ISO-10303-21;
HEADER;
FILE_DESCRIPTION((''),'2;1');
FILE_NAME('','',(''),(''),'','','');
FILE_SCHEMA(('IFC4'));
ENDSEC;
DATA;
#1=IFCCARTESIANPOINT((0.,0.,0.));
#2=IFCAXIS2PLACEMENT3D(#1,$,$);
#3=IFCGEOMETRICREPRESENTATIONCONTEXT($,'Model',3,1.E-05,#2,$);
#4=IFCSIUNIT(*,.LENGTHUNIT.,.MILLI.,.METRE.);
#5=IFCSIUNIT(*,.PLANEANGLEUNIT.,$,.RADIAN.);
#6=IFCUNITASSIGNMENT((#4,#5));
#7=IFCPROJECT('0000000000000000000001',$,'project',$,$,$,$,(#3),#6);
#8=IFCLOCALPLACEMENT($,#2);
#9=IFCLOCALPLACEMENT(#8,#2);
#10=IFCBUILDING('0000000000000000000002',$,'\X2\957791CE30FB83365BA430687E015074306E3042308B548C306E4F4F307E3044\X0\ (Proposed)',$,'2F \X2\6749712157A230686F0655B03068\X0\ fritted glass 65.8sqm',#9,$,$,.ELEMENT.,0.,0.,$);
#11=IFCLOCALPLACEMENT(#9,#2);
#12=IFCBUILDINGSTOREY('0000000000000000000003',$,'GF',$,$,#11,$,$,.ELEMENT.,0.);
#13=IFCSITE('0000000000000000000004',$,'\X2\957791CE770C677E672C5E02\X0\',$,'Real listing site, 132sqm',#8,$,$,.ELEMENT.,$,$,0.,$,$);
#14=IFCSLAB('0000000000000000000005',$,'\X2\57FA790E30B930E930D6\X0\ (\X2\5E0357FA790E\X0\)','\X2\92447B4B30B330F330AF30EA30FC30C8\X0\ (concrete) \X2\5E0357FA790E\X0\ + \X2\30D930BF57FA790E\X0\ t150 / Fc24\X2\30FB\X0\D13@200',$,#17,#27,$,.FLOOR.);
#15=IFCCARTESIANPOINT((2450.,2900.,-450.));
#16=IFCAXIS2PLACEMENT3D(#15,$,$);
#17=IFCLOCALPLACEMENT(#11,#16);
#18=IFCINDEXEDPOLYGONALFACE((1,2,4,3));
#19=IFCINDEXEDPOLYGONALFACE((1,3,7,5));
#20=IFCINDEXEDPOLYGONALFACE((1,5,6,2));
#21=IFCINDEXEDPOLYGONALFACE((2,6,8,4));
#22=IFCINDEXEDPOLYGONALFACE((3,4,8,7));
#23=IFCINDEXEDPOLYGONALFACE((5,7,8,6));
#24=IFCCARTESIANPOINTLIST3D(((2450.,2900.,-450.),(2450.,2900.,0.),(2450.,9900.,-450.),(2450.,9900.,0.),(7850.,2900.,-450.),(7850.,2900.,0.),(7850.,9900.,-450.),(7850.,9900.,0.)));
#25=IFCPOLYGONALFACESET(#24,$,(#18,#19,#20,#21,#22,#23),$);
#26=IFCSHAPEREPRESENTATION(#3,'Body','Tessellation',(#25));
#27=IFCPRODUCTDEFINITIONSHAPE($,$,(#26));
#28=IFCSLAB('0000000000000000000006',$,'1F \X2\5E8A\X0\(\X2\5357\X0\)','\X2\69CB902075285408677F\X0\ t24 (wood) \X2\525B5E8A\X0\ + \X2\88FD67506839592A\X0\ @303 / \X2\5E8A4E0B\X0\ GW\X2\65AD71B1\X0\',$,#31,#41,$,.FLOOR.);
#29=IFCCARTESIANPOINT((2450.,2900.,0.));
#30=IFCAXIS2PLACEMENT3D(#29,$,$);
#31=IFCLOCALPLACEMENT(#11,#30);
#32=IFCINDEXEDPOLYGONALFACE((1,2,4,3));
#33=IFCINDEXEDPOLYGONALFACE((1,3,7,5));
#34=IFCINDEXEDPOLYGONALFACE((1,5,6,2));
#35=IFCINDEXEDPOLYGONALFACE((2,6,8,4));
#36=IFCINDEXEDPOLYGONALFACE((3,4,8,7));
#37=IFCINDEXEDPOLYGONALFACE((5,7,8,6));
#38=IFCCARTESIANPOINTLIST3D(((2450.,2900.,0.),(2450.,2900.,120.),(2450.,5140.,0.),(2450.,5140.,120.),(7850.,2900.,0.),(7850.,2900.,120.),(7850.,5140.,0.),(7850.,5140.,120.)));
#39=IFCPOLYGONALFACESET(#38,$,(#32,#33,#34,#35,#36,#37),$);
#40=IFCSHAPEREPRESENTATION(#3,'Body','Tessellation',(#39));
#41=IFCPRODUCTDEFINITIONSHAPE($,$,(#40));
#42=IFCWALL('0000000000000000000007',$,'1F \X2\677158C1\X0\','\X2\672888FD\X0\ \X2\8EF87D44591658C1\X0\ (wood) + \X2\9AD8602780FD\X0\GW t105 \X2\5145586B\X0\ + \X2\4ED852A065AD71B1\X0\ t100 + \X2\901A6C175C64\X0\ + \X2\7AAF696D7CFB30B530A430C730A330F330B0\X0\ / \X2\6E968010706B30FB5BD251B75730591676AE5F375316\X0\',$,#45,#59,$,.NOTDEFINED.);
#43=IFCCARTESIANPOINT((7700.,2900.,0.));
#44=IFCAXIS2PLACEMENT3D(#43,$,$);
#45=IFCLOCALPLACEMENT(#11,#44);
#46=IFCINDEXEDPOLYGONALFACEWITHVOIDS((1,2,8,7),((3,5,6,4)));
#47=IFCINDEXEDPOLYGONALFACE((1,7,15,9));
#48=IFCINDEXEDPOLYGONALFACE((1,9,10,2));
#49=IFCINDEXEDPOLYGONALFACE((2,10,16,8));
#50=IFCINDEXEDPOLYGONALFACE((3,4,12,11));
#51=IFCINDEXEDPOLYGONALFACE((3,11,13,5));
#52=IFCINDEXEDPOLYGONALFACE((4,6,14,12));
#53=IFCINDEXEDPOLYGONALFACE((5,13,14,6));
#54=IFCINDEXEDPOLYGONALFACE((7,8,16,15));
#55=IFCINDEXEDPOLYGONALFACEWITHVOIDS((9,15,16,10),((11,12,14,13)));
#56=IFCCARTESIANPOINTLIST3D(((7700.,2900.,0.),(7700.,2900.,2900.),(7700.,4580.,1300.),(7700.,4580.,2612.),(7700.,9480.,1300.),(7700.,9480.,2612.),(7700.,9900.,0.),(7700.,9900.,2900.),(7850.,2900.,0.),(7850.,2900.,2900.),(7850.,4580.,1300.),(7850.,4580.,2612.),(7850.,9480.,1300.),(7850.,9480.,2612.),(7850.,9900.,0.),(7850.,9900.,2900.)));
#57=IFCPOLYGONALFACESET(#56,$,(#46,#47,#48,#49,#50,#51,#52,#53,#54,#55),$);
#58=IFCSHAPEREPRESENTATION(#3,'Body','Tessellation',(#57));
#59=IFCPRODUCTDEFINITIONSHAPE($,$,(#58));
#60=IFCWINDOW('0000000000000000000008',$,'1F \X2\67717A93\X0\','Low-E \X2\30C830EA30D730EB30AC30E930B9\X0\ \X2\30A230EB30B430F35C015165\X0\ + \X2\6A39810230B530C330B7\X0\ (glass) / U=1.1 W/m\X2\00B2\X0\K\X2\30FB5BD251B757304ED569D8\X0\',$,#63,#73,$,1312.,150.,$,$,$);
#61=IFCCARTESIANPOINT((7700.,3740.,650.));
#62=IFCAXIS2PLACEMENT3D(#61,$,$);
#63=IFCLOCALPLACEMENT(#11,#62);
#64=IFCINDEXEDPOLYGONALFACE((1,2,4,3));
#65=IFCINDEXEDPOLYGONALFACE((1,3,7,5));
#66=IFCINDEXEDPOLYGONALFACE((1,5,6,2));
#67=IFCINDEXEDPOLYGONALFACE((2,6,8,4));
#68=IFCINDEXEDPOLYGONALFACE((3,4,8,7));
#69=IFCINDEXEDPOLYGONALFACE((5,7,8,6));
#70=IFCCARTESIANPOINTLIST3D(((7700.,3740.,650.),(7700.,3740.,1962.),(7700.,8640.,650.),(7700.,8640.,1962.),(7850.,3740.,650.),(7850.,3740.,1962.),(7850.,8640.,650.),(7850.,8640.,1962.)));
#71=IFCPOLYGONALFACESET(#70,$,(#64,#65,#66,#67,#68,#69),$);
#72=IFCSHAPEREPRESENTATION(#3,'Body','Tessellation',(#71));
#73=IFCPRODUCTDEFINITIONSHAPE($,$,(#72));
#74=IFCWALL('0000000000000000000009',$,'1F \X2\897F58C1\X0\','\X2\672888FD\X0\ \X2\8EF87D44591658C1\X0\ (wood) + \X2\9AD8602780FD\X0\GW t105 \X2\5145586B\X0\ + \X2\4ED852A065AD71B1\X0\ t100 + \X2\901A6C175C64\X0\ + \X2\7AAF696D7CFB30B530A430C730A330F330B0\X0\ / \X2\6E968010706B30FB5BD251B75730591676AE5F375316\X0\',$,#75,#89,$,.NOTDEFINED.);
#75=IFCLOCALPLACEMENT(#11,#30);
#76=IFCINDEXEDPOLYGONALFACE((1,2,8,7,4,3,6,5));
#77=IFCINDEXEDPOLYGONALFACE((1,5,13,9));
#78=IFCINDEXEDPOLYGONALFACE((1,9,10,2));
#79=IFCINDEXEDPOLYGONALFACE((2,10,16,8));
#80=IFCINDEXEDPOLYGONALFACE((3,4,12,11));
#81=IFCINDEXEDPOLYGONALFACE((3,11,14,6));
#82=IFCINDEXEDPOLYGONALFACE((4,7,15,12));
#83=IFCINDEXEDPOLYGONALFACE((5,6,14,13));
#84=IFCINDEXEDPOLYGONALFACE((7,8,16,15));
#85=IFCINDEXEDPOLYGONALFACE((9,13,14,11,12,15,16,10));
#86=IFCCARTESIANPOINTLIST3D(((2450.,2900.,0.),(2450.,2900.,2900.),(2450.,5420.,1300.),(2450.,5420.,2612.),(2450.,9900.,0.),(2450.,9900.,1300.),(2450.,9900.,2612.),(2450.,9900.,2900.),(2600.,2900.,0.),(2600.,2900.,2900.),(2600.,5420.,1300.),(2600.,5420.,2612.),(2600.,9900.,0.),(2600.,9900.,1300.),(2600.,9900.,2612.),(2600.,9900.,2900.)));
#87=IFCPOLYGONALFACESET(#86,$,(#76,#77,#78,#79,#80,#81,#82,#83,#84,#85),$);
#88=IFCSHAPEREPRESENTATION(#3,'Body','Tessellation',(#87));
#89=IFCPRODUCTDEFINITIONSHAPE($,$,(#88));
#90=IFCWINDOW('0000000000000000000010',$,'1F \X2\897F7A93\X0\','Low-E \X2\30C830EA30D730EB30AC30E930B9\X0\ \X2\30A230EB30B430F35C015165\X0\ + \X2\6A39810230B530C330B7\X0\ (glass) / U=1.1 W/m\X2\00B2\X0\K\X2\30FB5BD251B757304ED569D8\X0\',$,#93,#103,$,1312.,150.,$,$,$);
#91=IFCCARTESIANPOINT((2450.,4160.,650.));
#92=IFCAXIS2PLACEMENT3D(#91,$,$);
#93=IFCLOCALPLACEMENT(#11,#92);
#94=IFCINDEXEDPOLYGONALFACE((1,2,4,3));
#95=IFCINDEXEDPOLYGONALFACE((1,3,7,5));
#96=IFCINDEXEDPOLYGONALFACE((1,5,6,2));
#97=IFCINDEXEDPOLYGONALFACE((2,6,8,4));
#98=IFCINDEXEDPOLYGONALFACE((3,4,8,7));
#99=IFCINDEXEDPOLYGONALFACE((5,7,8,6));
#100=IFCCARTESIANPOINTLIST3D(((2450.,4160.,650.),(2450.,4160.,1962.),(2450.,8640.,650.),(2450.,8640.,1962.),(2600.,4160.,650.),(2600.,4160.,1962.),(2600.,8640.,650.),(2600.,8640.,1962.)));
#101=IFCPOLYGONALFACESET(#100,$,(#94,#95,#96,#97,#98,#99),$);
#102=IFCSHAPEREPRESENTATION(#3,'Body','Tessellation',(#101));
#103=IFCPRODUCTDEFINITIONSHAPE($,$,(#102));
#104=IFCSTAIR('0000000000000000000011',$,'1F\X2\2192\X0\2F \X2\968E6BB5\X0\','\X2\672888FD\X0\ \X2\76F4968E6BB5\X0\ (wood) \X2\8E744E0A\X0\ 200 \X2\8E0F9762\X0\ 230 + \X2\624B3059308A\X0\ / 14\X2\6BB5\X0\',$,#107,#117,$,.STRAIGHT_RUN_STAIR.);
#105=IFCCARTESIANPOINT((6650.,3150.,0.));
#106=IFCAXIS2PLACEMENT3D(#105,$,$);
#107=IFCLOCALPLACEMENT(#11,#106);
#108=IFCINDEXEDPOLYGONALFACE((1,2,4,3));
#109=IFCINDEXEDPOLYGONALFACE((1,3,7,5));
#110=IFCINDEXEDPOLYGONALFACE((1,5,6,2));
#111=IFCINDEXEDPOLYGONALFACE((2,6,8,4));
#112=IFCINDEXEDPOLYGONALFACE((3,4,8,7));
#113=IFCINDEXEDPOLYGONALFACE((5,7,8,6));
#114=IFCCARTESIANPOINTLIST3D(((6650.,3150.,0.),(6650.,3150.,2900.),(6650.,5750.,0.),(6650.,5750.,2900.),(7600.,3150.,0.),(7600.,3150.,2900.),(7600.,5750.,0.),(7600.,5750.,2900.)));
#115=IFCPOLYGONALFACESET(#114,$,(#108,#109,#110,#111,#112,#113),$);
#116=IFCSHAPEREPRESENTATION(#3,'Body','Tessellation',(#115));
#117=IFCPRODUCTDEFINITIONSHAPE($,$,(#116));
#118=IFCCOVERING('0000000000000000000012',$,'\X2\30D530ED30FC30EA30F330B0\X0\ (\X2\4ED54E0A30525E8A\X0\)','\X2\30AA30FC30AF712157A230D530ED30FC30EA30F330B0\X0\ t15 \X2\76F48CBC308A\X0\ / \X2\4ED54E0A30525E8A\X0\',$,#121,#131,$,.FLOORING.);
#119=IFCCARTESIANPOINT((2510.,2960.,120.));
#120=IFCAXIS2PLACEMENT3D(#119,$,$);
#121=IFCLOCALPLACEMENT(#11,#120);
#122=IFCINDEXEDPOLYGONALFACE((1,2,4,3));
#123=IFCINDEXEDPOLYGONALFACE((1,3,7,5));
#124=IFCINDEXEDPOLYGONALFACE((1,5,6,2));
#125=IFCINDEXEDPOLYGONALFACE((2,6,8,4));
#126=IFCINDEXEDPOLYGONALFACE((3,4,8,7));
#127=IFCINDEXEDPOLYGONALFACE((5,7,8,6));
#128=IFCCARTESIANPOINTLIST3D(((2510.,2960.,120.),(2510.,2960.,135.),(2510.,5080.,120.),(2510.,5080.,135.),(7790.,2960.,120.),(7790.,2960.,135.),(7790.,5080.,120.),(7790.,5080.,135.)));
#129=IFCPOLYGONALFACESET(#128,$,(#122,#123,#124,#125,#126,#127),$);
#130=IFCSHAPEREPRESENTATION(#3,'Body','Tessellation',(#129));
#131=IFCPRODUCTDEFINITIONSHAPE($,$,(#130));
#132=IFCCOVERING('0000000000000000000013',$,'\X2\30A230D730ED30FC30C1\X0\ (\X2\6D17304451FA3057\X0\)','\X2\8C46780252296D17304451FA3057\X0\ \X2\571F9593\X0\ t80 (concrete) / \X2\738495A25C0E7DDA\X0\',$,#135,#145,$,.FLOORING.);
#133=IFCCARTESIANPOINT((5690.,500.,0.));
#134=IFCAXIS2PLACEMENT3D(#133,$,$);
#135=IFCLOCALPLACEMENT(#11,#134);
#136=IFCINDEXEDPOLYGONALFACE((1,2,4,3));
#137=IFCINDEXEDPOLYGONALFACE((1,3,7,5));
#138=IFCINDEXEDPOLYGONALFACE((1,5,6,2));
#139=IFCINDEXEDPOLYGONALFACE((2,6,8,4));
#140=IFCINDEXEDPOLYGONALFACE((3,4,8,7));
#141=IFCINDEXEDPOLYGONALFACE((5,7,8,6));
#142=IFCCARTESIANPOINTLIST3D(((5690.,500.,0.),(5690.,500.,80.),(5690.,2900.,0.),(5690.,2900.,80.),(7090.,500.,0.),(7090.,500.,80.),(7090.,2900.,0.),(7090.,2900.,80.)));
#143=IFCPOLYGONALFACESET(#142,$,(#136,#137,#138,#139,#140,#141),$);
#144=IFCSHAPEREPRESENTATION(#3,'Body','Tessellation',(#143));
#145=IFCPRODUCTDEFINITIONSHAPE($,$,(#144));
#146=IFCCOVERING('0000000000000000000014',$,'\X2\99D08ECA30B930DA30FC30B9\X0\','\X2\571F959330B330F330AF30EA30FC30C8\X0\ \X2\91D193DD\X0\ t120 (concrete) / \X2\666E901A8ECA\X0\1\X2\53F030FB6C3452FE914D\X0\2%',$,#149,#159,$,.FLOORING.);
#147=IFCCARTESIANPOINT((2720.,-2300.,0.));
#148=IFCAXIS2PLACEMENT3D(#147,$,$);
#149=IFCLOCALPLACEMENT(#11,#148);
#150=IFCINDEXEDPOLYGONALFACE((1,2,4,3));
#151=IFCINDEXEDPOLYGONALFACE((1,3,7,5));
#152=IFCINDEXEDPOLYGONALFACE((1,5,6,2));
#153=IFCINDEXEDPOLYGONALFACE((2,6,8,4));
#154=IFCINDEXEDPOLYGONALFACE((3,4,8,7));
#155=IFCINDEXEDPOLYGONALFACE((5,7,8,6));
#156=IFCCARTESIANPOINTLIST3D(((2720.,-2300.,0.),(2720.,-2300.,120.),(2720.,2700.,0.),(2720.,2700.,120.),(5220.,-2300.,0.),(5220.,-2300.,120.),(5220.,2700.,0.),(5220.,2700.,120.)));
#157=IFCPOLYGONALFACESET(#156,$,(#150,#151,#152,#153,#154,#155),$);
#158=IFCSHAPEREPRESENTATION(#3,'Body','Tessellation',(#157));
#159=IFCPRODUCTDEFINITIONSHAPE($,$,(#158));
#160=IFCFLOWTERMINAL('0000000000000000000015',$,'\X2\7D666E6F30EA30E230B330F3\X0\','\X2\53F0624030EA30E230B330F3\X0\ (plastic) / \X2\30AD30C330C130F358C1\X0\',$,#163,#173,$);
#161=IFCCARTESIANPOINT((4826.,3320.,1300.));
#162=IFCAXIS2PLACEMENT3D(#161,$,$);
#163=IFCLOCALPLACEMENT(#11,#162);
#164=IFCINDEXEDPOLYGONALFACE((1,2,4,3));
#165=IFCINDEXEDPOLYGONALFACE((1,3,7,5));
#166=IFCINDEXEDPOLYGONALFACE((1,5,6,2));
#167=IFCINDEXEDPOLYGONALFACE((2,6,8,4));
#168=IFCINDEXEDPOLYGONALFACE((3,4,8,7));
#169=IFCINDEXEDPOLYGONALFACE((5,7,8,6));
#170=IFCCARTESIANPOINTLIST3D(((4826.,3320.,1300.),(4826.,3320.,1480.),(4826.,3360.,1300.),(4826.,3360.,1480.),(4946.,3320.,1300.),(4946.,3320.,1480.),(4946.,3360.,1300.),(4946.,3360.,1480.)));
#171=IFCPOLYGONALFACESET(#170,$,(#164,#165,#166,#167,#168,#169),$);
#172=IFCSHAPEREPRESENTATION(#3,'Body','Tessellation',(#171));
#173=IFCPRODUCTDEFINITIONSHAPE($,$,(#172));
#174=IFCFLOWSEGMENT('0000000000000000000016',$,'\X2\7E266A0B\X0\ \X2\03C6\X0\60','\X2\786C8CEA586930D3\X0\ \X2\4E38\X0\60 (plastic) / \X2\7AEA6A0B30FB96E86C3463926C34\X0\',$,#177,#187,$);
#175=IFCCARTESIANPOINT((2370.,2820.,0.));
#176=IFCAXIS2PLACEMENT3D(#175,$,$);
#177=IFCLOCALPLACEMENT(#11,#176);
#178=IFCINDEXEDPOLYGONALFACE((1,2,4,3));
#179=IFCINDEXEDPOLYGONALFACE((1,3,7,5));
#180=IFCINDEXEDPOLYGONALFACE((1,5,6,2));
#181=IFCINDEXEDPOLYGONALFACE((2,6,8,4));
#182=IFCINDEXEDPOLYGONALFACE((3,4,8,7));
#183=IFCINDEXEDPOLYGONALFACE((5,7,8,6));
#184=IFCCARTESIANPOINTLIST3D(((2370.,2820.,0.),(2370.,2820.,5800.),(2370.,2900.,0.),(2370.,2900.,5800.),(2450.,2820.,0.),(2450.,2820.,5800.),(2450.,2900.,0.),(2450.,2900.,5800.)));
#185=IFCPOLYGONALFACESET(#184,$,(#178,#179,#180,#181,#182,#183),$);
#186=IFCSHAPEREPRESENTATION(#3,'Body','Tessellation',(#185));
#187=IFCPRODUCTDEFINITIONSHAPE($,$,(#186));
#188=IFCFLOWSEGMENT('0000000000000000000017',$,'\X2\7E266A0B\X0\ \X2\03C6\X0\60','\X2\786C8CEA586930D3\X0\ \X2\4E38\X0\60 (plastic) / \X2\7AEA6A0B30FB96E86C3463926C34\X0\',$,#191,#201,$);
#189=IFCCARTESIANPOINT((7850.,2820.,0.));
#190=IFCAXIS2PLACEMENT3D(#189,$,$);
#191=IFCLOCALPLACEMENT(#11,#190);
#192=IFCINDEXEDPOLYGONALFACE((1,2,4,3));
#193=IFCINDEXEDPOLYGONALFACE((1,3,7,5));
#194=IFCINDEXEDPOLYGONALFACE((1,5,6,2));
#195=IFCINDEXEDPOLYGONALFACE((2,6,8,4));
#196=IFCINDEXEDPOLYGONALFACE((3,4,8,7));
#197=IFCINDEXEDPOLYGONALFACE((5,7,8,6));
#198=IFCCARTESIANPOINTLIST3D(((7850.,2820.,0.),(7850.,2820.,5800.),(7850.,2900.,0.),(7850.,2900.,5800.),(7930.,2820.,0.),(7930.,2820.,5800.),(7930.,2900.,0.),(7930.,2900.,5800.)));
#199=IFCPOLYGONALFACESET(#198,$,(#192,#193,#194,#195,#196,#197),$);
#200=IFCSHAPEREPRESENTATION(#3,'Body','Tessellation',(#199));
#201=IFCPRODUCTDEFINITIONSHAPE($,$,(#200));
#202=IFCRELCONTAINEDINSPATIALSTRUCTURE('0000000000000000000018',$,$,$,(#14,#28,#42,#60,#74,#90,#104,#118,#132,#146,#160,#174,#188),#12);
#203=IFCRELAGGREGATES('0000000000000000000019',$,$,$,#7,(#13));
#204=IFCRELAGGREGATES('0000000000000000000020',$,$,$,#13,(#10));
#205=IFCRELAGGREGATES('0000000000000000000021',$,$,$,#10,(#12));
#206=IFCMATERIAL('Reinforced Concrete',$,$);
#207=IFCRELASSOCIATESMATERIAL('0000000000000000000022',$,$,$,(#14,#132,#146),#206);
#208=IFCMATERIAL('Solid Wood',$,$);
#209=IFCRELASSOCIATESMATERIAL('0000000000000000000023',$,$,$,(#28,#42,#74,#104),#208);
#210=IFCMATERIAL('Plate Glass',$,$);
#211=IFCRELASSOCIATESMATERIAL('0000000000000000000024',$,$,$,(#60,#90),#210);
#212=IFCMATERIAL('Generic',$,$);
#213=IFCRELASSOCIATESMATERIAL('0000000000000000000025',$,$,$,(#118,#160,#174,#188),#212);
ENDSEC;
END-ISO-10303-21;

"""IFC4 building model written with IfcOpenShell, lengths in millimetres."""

from ifc_helpers import new_model, si_unit, frame, frame_2d, origin, place, context, project, spatial, rectangle, extrude, material, element, fill, save


model = new_model("IFC4")

# Units and contexts
model_context = context("Model", 3, precision=1e-05, world=origin())
ifc_project = project(units=[si_unit("LENGTHUNIT", "METRE", prefix="MILLI"), si_unit("PLANEANGLEUNIT", "RADIAN")], contexts=[model_context])

# Site, building, storey
site_placement = place(None, origin())
site = spatial("IfcSite", under=ifc_project, at=site_placement, Name="長野県松本市", ObjectType="Real listing site, 132sqm", CompositionType="ELEMENT", RefElevation=0.0)
building_placement = place(site_placement, origin())
building = spatial("IfcBuilding", under=site, at=building_placement, Name="長野・茶室と縁側のある和の住まい (Proposed)", ObjectType="2F 杉無垢と漆喰と fritted glass 65.8sqm", CompositionType="ELEMENT", ElevationOfRefHeight=0.0, ElevationOfTerrain=0.0)
storey_placement = place(building_placement, origin())
storey = spatial("IfcBuildingStorey", under=building, at=storey_placement, Name="GF", CompositionType="ELEMENT", Elevation=0.0)

# Shared definitions
ifc_material_1 = material(Name="Solid Wood")

# Slabs
ifc_material_2 = material(Name="Reinforced Concrete")
slab_1_placement = place(storey_placement, frame((2450.0, 2900.0, -450.0)))
element("IfcSlab", 1, at=slab_1_placement, inside=storey, material=ifc_material_2, Name="基礎スラブ (布基礎)", Description="鉄筋コンクリート (concrete) 布基礎 + ベタ基礎 t150 / Fc24・D13@200", PredefinedType="FLOOR", context=model_context, shape_type="SweptSolid", body=[
    extrude(rectangle(XDim=5400.0, YDim=7000.0, at=frame_2d((2700.0, 3500.0))), frame((2450.0, 2900.0, -450.0)), (0.0, 0.0, 1.0), 450.0),
])
slab_2_placement = place(storey_placement, frame((2450.0, 2900.0, 0.0)))
element("IfcSlab", 2, at=slab_2_placement, inside=storey, material=ifc_material_1, Name="1F 床(南)", Description="構造用合板 t24 (wood) 剛床 + 製材根太 @303 / 床下 GW断熱", PredefinedType="FLOOR", context=model_context, shape_type="SweptSolid", body=[
    extrude(rectangle(XDim=5400.0, YDim=2240.0, at=frame_2d((2700.0, 1120.0))), frame((2450.0, 2900.0, 0.0)), (0.0, 0.0, 1.0), 120.0),
])

# Shared definitions
ifc_material_3 = material(Name="Plate Glass")

# Walls, openings, windows
wall_1_placement = place(storey_placement, frame((7700.0, 2900.0, 0.0)))
wall_1 = element("IfcWall", 3, at=wall_1_placement, inside=storey, material=ifc_material_1, Name="1F 東壁", Description="木製 軸組外壁 (wood) + 高性能GW t105 充填 + 付加断熱 t100 + 通気層 + 窯業系サイディング / 準耐火・寒冷地外皮強化", PredefinedType="NOTDEFINED", context=model_context, shape_type="SweptSolid", body=[
    extrude(rectangle(XDim=150.0, YDim=7000.0, at=frame_2d((75.0, 3500.0))), frame((7700.0, 2900.0, 0.0)), (0.0, 0.0, 1.0), 2900.0),
])
opening_1_placement = place(storey_placement, frame((7700.0, 3740.0, 650.0)))
opening_1 = element("IfcOpeningElement", 4, at=opening_1_placement, cuts=wall_1, PredefinedType="NOTDEFINED", context=model_context, shape_type="SweptSolid", body=[
    extrude(rectangle(XDim=150.0, YDim=4900.0, at=frame_2d((75.0, 2450.0))), frame((7700.0, 3740.0, 650.0)), (0.0, 0.0, 1.0), 1312.0),
])
window_1_placement = place(storey_placement, frame((7700.0, 3740.0, 650.0)))
window_1 = element("IfcWindow", 5, at=window_1_placement, inside=storey, material=ifc_material_3, Name="1F 東窓", Description="Low-E トリプルガラス アルゴン封入 + 樹脂サッシ (glass) / U=1.1 W/m²K・寒冷地仕様", OverallHeight=1312.0, OverallWidth=150.0, context=model_context, shape_type="SweptSolid", body=[
    extrude(rectangle(XDim=150.0, YDim=4900.0, at=frame_2d((75.0, 2450.0))), frame((7700.0, 3740.0, 650.0)), (0.0, 0.0, 1.0), 1312.0),
])
fill(opening_1, window_1)
wall_2_placement = place(storey_placement, frame((2450.0, 2900.0, 0.0)))
wall_2 = element("IfcWall", 6, at=wall_2_placement, inside=storey, material=ifc_material_1, Name="1F 西壁", Description="木製 軸組外壁 (wood) + 高性能GW t105 充填 + 付加断熱 t100 + 通気層 + 窯業系サイディング / 準耐火・寒冷地外皮強化", PredefinedType="NOTDEFINED", context=model_context, shape_type="SweptSolid", body=[
    extrude(rectangle(XDim=150.0, YDim=7000.0, at=frame_2d((75.0, 3500.0))), frame((2450.0, 2900.0, 0.0)), (0.0, 0.0, 1.0), 2900.0),
])
opening_2_placement = place(storey_placement, frame((2450.0, 4160.0, 650.0)))
opening_2 = element("IfcOpeningElement", 7, at=opening_2_placement, cuts=wall_2, PredefinedType="NOTDEFINED", context=model_context, shape_type="SweptSolid", body=[
    extrude(rectangle(XDim=150.0, YDim=4480.0, at=frame_2d((75.0, 2240.0))), frame((2450.0, 4160.0, 650.0)), (0.0, 0.0, 1.0), 1312.0),
])
window_2_placement = place(storey_placement, frame((2450.0, 4160.0, 650.0)))
window_2 = element("IfcWindow", 8, at=window_2_placement, inside=storey, material=ifc_material_3, Name="1F 西窓", Description="Low-E トリプルガラス アルゴン封入 + 樹脂サッシ (glass) / U=1.1 W/m²K・寒冷地仕様", OverallHeight=1312.0, OverallWidth=150.0, context=model_context, shape_type="SweptSolid", body=[
    extrude(rectangle(XDim=150.0, YDim=4480.0, at=frame_2d((75.0, 2240.0))), frame((2450.0, 4160.0, 650.0)), (0.0, 0.0, 1.0), 1312.0),
])
fill(opening_2, window_2)

# Stair
stair_placement = place(storey_placement, frame((6650.0, 3150.0, 0.0)))
element("IfcStair", 9, at=stair_placement, inside=storey, material=ifc_material_1, Name="1F→2F 階段", Description="木製 直階段 (wood) 蹴上 200 踏面 230 + 手すり / 14段", PredefinedType="STRAIGHT_RUN_STAIR", context=model_context, shape_type="SweptSolid", body=[
    extrude(rectangle(XDim=950.0, YDim=2600.0, at=frame_2d((475.0, 1300.0))), frame((6650.0, 3150.0, 0.0)), (0.0, 0.0, 1.0), 2900.0),
])

# Coverings
ifc_material_4 = material(Name="Generic")
covering_1_placement = place(storey_placement, frame((2510.0, 2960.0, 120.0)))
element("IfcCovering", 10, at=covering_1_placement, inside=storey, material=ifc_material_4, Name="フローリング (仕上げ床)", Description="オーク無垢フローリング t15 直貼り / 仕上げ床", PredefinedType="FLOORING", context=model_context, shape_type="SweptSolid", body=[
    extrude(rectangle(XDim=5280.0, YDim=2120.0, at=frame_2d((2640.0, 1060.0))), frame((2510.0, 2960.0, 120.0)), (0.0, 0.0, 1.0), 15.0),
])
covering_2_placement = place(storey_placement, frame((5690.0, 500.0, 0.0)))
element("IfcCovering", 11, at=covering_2_placement, inside=storey, material=ifc_material_2, Name="アプローチ (洗い出し)", Description="豆砂利洗い出し 土間 t80 (concrete) / 玄関導線", PredefinedType="FLOORING", context=model_context, shape_type="SweptSolid", body=[
    extrude(rectangle(XDim=1400.0, YDim=2400.0, at=frame_2d((700.0, 1200.0))), frame((5690.0, 500.0, 0.0)), (0.0, 0.0, 1.0), 80.0),
])
covering_3_placement = place(storey_placement, frame((2720.0, -2300.0, 0.0)))
element("IfcCovering", 12, at=covering_3_placement, inside=storey, material=ifc_material_2, Name="駐車スペース", Description="土間コンクリート 金鏝 t120 (concrete) / 普通車1台・水勾配2%", PredefinedType="FLOORING", context=model_context, shape_type="SweptSolid", body=[
    extrude(rectangle(XDim=2500.0, YDim=5000.0, at=frame_2d((1250.0, 2500.0))), frame((2720.0, -2300.0, 0.0)), (0.0, 0.0, 1.0), 120.0),
])

# Flow terminal
flow_terminal_placement = place(storey_placement, frame((4826.0, 3320.0, 1300.0)))
element("IfcFlowTerminal", 13, at=flow_terminal_placement, inside=storey, material=ifc_material_4, Name="給湯リモコン", Description="台所リモコン (plastic) / キッチン壁", context=model_context, shape_type="SweptSolid", body=[
    extrude(rectangle(XDim=120.0, YDim=40.0, at=frame_2d((60.0, 20.0))), frame((4826.0, 3320.0, 1300.0)), (0.0, 0.0, 1.0), 180.0),
])

# Flow segments
flow_segment_1_placement = place(storey_placement, frame((2370.0, 2820.0, 0.0)))
element("IfcFlowSegment", 14, at=flow_segment_1_placement, inside=storey, material=ifc_material_4, Name="縦樋 φ60", Description="硬質塩ビ 丸60 (plastic) / 竪樋・雨水排水", context=model_context, shape_type="SweptSolid", body=[
    extrude(rectangle(XDim=80.0, YDim=80.0, at=frame_2d((40.0, 40.0))), frame((2370.0, 2820.0, 0.0)), (0.0, 0.0, 1.0), 5800.0),
])
flow_segment_2_placement = place(storey_placement, frame((7850.0, 2820.0, 0.0)))
element("IfcFlowSegment", 15, at=flow_segment_2_placement, inside=storey, material=ifc_material_4, Name="縦樋 φ60", Description="硬質塩ビ 丸60 (plastic) / 竪樋・雨水排水", context=model_context, shape_type="SweptSolid", body=[
    extrude(rectangle(XDim=80.0, YDim=80.0, at=frame_2d((40.0, 40.0))), frame((7850.0, 2820.0, 0.0)), (0.0, 0.0, 1.0), 5800.0),
])

save(model, "model.ifc")
